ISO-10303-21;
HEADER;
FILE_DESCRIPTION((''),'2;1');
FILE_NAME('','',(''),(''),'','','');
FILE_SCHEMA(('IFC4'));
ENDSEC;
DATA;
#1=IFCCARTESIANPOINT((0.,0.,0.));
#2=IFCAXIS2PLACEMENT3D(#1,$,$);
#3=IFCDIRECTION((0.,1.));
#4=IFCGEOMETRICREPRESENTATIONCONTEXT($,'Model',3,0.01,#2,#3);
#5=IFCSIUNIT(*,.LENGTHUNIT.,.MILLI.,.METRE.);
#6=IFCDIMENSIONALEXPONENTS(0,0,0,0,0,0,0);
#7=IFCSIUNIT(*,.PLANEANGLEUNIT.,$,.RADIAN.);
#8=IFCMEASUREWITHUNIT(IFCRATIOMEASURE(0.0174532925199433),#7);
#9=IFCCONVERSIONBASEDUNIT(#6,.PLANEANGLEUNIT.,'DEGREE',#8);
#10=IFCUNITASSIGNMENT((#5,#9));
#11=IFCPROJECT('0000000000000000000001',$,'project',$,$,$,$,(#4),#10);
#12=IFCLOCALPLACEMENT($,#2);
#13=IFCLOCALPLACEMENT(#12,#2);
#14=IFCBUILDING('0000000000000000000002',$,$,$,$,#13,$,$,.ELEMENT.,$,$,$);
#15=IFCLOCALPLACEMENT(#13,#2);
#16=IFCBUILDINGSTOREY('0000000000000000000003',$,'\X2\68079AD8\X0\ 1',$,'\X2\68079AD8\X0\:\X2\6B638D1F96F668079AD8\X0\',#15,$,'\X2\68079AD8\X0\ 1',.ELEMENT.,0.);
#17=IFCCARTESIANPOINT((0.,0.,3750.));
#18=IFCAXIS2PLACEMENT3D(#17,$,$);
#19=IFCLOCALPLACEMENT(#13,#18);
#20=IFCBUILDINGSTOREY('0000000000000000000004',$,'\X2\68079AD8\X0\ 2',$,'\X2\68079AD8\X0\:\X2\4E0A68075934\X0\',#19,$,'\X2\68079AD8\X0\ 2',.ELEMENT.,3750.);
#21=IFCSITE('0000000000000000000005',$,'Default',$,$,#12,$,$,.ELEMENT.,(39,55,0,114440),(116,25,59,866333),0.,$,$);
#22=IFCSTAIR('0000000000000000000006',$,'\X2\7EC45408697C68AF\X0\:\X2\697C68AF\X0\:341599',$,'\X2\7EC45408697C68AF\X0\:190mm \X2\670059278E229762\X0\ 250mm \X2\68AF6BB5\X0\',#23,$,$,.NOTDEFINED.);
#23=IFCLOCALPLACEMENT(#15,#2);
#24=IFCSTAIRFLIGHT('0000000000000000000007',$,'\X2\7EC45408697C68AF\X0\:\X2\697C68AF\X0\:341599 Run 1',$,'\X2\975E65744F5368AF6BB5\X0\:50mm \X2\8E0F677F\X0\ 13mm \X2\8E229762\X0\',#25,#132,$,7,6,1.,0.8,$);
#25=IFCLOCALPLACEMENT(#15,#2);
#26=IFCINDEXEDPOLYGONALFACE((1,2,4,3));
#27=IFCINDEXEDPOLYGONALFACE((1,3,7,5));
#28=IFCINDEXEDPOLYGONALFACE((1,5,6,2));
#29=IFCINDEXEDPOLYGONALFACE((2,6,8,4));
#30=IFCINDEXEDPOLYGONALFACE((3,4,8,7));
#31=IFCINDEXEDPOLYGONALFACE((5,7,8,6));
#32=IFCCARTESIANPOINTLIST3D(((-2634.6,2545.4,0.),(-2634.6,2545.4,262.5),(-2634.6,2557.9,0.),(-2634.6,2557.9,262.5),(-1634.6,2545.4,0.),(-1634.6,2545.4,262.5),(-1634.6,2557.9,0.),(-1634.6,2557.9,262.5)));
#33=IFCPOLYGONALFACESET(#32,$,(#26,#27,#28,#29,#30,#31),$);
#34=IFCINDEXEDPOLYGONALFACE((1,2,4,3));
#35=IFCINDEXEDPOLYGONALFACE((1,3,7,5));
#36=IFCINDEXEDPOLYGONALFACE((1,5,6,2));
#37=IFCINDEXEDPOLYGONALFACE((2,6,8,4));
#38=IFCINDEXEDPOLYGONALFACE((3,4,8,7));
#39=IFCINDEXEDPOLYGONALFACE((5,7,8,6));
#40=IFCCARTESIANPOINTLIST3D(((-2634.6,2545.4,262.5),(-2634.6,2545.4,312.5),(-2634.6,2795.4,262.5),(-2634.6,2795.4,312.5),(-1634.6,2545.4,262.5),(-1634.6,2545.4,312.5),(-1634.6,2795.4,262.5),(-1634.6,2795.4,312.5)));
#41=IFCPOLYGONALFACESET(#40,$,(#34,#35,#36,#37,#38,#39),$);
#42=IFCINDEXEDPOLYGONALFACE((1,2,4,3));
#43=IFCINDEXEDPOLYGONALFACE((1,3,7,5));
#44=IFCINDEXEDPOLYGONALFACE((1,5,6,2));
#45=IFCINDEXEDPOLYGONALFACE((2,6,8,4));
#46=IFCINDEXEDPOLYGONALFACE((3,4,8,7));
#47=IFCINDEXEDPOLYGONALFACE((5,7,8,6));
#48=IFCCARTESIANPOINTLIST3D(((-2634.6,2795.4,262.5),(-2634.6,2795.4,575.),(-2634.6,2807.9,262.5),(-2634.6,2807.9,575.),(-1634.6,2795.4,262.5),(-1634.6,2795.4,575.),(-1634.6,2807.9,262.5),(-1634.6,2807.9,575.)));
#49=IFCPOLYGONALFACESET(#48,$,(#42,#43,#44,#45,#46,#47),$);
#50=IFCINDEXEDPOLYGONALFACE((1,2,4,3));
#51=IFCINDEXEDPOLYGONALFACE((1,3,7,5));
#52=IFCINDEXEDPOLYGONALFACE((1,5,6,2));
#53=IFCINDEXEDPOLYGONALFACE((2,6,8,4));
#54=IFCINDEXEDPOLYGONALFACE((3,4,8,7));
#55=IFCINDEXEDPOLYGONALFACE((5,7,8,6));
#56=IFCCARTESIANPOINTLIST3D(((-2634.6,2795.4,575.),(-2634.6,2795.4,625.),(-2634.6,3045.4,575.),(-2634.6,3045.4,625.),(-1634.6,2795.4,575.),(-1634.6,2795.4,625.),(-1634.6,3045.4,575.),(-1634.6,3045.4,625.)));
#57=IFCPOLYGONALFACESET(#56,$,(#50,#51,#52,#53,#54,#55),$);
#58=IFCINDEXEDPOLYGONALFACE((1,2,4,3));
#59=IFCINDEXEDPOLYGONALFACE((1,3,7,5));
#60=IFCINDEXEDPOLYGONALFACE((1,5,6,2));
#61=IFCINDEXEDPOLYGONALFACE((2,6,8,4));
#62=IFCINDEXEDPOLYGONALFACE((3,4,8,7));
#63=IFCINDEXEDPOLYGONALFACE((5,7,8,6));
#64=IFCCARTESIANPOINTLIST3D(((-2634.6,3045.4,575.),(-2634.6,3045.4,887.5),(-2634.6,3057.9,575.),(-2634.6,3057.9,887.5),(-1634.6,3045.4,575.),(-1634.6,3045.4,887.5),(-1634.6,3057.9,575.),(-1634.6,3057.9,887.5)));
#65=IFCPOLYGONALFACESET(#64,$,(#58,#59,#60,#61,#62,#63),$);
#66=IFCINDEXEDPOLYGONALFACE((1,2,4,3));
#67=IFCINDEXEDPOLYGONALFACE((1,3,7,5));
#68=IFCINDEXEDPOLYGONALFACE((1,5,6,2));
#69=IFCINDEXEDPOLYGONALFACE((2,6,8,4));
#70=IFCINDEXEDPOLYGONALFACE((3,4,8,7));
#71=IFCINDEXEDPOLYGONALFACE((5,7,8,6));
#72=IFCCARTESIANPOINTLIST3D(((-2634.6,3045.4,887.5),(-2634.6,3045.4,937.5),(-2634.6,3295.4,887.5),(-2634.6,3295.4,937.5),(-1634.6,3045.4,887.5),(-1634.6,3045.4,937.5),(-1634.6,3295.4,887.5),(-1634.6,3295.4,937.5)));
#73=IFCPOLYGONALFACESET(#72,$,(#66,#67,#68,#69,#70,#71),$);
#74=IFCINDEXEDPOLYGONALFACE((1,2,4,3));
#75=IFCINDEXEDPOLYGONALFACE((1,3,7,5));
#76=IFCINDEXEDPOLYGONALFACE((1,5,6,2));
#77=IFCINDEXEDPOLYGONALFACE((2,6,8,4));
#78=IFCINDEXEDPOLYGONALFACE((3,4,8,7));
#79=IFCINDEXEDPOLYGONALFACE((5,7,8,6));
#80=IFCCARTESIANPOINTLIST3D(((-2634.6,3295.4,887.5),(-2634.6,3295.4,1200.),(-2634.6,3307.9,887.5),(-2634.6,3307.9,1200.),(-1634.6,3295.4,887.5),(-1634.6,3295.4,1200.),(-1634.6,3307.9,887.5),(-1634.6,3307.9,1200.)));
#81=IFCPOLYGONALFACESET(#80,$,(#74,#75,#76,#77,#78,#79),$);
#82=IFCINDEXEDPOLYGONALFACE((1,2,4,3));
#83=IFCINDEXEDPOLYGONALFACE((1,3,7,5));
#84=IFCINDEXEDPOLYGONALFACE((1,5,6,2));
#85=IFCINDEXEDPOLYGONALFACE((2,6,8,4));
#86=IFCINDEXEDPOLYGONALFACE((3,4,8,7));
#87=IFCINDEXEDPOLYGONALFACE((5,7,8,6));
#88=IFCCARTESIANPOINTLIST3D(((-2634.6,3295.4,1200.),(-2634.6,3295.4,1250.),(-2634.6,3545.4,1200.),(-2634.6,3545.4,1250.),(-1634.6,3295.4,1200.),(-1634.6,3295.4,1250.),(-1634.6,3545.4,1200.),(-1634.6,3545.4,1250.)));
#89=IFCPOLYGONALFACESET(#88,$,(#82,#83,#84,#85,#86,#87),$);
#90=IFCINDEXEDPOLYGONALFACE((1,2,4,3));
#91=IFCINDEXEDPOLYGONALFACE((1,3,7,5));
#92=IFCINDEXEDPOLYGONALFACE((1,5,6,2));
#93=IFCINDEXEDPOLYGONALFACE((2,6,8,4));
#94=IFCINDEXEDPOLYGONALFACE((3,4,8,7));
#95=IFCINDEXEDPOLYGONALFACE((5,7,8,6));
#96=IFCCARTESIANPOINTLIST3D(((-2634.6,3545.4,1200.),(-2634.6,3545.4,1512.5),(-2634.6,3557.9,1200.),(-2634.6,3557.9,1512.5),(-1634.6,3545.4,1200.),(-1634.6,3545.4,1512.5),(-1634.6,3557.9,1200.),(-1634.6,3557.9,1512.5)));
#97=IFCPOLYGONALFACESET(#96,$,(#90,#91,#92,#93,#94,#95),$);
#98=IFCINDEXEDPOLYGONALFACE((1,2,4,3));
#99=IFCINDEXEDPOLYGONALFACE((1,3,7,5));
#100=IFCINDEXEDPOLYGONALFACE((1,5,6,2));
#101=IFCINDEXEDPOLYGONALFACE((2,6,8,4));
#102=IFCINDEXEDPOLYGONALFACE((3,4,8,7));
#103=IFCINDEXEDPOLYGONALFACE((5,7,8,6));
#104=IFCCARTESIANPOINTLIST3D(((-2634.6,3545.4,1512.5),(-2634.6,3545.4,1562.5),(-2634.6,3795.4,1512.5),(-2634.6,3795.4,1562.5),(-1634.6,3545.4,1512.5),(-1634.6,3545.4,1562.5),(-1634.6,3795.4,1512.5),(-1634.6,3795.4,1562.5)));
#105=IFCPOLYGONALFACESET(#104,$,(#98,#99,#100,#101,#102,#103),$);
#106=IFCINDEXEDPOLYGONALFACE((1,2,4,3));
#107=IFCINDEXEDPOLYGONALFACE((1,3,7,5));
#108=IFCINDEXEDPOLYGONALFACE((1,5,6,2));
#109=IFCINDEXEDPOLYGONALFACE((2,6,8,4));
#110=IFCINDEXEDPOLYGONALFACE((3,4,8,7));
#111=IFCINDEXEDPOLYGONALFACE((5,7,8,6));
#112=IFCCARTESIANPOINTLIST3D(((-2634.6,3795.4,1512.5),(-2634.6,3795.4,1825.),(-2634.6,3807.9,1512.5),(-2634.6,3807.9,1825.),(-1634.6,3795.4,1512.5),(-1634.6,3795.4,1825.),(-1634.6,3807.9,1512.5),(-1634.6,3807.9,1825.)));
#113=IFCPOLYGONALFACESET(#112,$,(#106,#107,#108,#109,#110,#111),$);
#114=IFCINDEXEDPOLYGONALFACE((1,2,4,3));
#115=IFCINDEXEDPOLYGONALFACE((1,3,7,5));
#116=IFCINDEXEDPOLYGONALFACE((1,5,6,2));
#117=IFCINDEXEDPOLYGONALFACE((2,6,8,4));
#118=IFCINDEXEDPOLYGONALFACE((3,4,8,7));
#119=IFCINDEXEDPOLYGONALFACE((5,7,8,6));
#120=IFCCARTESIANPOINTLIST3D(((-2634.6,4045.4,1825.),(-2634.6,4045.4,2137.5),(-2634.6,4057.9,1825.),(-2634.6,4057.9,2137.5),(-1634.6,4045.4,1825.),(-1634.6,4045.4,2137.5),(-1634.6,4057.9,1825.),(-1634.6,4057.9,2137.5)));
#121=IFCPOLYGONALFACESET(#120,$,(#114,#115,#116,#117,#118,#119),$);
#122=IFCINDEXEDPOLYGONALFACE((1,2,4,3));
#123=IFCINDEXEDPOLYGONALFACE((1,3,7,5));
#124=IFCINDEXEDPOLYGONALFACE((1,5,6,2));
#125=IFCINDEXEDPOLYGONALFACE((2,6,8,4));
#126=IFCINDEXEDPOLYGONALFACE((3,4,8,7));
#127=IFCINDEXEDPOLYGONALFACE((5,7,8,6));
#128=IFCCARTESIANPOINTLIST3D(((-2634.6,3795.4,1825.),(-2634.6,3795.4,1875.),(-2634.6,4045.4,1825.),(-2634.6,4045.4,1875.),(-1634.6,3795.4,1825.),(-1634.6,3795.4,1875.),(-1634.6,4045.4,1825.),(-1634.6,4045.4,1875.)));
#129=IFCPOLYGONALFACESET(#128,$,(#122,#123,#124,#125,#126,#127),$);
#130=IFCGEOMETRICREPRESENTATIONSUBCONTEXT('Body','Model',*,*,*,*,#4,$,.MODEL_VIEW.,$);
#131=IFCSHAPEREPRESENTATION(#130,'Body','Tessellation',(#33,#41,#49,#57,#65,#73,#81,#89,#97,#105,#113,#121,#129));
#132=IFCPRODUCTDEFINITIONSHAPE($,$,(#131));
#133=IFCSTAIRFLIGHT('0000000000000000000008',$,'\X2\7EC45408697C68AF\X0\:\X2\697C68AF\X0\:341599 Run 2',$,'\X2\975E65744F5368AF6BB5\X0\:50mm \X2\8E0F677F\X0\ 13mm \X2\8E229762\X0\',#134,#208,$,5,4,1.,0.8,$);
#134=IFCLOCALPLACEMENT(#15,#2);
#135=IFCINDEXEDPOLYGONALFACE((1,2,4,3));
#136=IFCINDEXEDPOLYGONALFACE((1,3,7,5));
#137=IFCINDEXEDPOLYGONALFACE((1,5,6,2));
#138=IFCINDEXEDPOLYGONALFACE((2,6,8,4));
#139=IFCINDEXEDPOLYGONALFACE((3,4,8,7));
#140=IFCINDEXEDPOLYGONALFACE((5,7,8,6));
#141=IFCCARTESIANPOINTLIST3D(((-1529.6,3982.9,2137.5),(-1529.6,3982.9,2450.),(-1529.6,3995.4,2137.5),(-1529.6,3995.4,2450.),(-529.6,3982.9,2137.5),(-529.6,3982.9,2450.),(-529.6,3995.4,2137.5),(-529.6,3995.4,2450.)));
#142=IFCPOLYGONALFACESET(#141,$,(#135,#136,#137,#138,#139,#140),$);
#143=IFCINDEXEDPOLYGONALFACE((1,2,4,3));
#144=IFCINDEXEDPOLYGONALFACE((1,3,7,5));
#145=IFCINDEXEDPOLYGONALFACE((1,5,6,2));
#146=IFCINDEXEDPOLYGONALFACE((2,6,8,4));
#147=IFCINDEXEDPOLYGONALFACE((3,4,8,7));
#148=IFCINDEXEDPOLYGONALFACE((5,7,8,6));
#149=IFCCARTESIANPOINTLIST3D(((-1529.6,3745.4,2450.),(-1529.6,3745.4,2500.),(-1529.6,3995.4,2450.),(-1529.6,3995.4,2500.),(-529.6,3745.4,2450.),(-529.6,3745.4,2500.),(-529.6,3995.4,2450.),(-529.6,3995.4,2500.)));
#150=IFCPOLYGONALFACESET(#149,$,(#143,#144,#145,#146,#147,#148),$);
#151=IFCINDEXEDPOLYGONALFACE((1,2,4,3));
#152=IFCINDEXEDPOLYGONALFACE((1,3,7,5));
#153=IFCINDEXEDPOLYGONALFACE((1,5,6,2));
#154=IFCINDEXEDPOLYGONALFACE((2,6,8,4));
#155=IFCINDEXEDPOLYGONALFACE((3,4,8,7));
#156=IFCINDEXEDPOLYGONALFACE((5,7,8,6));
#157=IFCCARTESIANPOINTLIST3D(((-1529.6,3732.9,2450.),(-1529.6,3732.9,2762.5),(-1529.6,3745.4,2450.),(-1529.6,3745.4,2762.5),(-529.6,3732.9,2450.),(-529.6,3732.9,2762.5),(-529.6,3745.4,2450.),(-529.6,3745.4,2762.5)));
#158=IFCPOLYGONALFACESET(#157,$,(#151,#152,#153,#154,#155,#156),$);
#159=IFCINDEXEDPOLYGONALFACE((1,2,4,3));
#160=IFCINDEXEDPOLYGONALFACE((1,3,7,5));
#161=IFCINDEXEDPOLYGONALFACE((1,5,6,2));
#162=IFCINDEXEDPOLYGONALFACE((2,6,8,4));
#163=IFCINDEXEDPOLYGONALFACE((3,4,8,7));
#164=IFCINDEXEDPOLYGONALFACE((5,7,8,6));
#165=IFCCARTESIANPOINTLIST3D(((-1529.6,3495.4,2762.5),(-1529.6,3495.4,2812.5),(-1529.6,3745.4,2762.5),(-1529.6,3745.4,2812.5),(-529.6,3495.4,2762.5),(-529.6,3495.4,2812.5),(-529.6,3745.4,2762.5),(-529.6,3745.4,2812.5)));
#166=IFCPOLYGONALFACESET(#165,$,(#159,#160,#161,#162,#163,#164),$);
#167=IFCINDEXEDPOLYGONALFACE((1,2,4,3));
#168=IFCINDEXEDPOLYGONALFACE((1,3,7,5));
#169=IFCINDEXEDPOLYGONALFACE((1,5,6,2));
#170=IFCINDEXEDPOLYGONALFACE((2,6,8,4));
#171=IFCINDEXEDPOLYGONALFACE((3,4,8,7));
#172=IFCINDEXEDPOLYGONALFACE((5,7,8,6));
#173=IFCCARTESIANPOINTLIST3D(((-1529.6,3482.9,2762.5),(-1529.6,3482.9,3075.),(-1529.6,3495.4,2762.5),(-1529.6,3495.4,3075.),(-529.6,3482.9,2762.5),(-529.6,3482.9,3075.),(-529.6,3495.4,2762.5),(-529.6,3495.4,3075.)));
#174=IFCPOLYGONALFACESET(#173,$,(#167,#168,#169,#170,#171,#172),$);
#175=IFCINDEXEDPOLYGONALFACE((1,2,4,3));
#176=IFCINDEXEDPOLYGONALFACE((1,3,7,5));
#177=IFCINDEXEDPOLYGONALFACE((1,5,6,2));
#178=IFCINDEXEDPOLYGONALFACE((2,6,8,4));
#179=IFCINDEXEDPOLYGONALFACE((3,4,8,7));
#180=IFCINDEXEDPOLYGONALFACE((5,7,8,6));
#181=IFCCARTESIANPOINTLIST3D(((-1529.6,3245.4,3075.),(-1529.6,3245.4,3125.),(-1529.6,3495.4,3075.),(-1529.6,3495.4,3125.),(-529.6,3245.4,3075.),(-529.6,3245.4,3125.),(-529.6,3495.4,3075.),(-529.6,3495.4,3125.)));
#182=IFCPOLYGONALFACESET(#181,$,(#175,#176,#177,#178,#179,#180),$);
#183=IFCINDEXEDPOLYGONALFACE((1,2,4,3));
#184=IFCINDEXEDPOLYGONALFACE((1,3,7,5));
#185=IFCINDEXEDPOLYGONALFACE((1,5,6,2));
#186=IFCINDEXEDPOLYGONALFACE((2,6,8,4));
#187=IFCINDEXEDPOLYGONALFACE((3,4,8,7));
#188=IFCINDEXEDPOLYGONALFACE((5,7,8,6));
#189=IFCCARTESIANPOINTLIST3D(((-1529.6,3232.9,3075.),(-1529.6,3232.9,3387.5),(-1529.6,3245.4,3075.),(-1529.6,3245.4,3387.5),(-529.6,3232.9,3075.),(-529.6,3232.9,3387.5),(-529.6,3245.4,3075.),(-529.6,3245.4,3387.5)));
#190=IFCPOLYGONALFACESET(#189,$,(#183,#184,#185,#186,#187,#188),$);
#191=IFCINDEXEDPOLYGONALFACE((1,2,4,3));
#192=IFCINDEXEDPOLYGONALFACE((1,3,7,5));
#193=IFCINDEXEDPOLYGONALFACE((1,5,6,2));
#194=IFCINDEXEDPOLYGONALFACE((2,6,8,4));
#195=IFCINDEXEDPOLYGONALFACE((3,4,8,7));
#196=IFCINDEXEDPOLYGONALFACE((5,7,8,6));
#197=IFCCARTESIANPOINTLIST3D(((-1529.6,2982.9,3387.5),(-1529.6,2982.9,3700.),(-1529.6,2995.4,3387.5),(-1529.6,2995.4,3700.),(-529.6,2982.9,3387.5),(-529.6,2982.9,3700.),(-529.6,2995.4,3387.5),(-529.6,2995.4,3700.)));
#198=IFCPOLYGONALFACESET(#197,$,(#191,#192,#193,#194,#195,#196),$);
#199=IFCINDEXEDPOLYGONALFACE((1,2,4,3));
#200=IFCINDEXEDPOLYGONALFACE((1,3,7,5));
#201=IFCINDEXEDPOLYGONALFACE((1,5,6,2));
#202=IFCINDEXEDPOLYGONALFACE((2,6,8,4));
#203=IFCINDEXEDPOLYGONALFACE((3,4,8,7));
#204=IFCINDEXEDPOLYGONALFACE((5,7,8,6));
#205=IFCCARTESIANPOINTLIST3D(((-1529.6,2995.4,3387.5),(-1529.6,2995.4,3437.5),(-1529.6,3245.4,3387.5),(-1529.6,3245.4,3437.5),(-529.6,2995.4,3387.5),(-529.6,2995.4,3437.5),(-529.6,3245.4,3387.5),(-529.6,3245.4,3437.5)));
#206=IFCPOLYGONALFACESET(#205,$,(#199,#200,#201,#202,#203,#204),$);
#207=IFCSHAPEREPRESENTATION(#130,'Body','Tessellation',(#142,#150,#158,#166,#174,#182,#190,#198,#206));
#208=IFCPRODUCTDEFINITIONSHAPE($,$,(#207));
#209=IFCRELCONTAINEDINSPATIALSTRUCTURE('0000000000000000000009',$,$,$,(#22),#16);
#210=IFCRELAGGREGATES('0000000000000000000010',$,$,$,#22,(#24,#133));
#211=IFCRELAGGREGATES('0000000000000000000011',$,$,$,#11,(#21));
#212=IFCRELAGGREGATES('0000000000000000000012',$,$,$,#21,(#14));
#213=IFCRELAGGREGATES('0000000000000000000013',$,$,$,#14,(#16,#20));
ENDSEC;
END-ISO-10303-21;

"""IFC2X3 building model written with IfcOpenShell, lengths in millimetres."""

from ifc_helpers import new_model, entity, si_unit, converted_unit, direction, frame, frame_2d, origin, origin_2d_with_axis, place, context, subcontext, project, spatial, rectangle, extrude, element, aggregate, save


model = new_model("IFC2X3")

# Units and contexts
model_context = context("Model", 3, precision=0.01, world=origin(), true_north=direction((0.0, 1.0)))
body_context = subcontext(model_context, "Body", "Model", "MODEL_VIEW")
ifc_project = project(units=[si_unit("LENGTHUNIT", "METRE", prefix="MILLI"), converted_unit("PLANEANGLEUNIT", "DEGREE", entity("IfcRatioMeasure", 0.0174532925199433), si_unit("PLANEANGLEUNIT", "RADIAN"), dimensions=[0, 0, 0, 0, 0, 0, 0])], contexts=[model_context])

# Site, building, storey
site_placement = place(None, origin())
site = spatial("IfcSite", under=ifc_project, at=site_placement, Name="Default", CompositionType="ELEMENT", RefLatitude=(39, 55, 0, 114440), RefLongitude=(116, 25, 59, 866333), RefElevation=0.0)
building_placement = place(site_placement, origin())
building = spatial("IfcBuilding", under=site, at=building_placement, CompositionType="ELEMENT")
storey_1_placement = place(building_placement, origin())
storey_1 = spatial("IfcBuildingStorey", under=building, at=storey_1_placement, Name="标高 1", ObjectType="标高:正负零标高", LongName="标高 1", CompositionType="ELEMENT", Elevation=0.0)

# Stair
stair_placement = place(storey_1_placement, origin())
stair = element("IfcStair", 1, at=stair_placement, inside=storey_1, Name="组合楼梯:楼梯:341599", ObjectType="组合楼梯:190mm 最大踢面 250mm 梯段", ShapeType="NOTDEFINED")

# Shared definitions
storey_2_placement = place(building_placement, frame((0.0, 0.0, 3750.0)))
storey_2 = spatial("IfcBuildingStorey", under=building, at=storey_2_placement, Name="标高 2", ObjectType="标高:上标头", LongName="标高 2", CompositionType="ELEMENT", Elevation=3750.0)

# Stair flights
stair_flight_1_placement = place(stair_placement, origin())
stair_flight_1 = element("IfcStairFlight", 2, at=stair_flight_1_placement, Name="组合楼梯:楼梯:341599 Run 1", ObjectType="非整体梯段:50mm 踏板 13mm 踢面", NumberOfRiser=7, NumberOfTreads=6, RiserHeight=1.0, TreadLength=0.8, context=body_context, shape_type="SweptSolid", body=[
    extrude(rectangle(XDim=1000.0, YDim=12.5, at=frame_2d((0.0, 0.0), x_axis=(1.0, 0.0))), frame((-2134.6, 2551.6, 0.0), z_axis=(0.0, 0.0, 1.0), x_axis=(-1.0, 0.0, 0.0)), (0.0, 0.0, 1.0), 262.5),
    extrude(rectangle(XDim=250.0, YDim=1000.0, at=frame_2d((0.0, 0.0), x_axis=(1.0, 0.0))), frame((-2134.6, 2670.4, 262.5), z_axis=(0.0, 0.0, 1.0), x_axis=(0.0, -1.0, 0.0)), (0.0, 0.0, 1.0), 50.0),
    extrude(rectangle(XDim=1000.0, YDim=12.5, at=frame_2d((0.0, 0.0), x_axis=(1.0, 0.0))), frame((-2134.6, 2801.6, 262.5), z_axis=(0.0, 0.0, 1.0), x_axis=(-1.0, 0.0, 0.0)), (0.0, 0.0, 1.0), 312.5),
    extrude(rectangle(XDim=250.0, YDim=1000.0, at=origin_2d_with_axis()), frame((-2134.6, 2920.4, 575.0), z_axis=(0.0, 0.0, 1.0), x_axis=(0.0, -1.0, 0.0)), (0.0, 0.0, 1.0), 50.0),
    extrude(rectangle(XDim=1000.0, YDim=12.5, at=frame_2d((0.0, 0.0), x_axis=(1.0, 0.0))), frame((-2134.6, 3051.6, 575.0), z_axis=(0.0, 0.0, 1.0), x_axis=(-1.0, 0.0, 0.0)), (0.0, 0.0, 1.0), 312.5),
    extrude(rectangle(XDim=250.0, YDim=1000.0, at=frame_2d((0.0, 0.0), x_axis=(1.0, 0.0))), frame((-2134.6, 3170.4, 887.5), z_axis=(0.0, 0.0, 1.0), x_axis=(0.0, -1.0, 0.0)), (0.0, 0.0, 1.0), 50.0),
    extrude(rectangle(XDim=1000.0, YDim=12.5, at=frame_2d((0.0, 0.0), x_axis=(1.0, 0.0))), frame((-2134.6, 3301.6, 887.5), z_axis=(0.0, 0.0, 1.0), x_axis=(-1.0, 0.0, 0.0)), (0.0, 0.0, 1.0), 312.5),
    extrude(rectangle(XDim=250.0, YDim=1000.0, at=frame_2d((0.0, 0.0), x_axis=(1.0, 0.0))), frame((-2134.6, 3420.4, 1200.0), z_axis=(0.0, 0.0, 1.0), x_axis=(0.0, -1.0, 0.0)), (0.0, 0.0, 1.0), 50.0),
    extrude(rectangle(XDim=1000.0, YDim=12.5, at=frame_2d((0.0, 0.0), x_axis=(1.0, 0.0))), frame((-2134.6, 3551.6, 1200.0), z_axis=(0.0, 0.0, 1.0), x_axis=(-1.0, 0.0, 0.0)), (0.0, 0.0, 1.0), 312.5),
    extrude(rectangle(XDim=250.0, YDim=1000.0, at=frame_2d((0.0, 0.0), x_axis=(1.0, 0.0))), frame((-2134.6, 3670.4, 1512.5), z_axis=(0.0, 0.0, 1.0), x_axis=(0.0, -1.0, 0.0)), (0.0, 0.0, 1.0), 50.0),
    extrude(rectangle(XDim=1000.0, YDim=12.5, at=frame_2d((0.0, 0.0), x_axis=(1.0, 0.0))), frame((-2134.6, 3801.6, 1512.5), z_axis=(0.0, 0.0, 1.0), x_axis=(-1.0, 0.0, 0.0)), (0.0, 0.0, 1.0), 312.5),
    extrude(rectangle(XDim=1000.0, YDim=12.5, at=frame_2d((0.0, 0.0), x_axis=(1.0, 0.0))), frame((-2134.6, 4051.6, 1825.0), z_axis=(0.0, 0.0, 1.0), x_axis=(-1.0, 0.0, 0.0)), (0.0, 0.0, 1.0), 312.5),
    extrude(rectangle(XDim=250.0, YDim=1000.0, at=frame_2d((0.0, 0.0), x_axis=(1.0, 0.0))), frame((-2134.6, 3920.4, 1825.0), z_axis=(0.0, 0.0, 1.0), x_axis=(0.0, -1.0, 0.0)), (0.0, 0.0, 1.0), 50.0),
])
stair_flight_2_placement = place(stair_placement, origin())
stair_flight_2 = element("IfcStairFlight", 3, at=stair_flight_2_placement, Name="组合楼梯:楼梯:341599 Run 2", ObjectType="非整体梯段:50mm 踏板 13mm 踢面", NumberOfRiser=5, NumberOfTreads=4, RiserHeight=1.0, TreadLength=0.8, context=body_context, shape_type="SweptSolid", body=[
    extrude(rectangle(XDim=1000.0, YDim=12.5, at=origin_2d_with_axis()), frame((-1029.6, 3989.1, 2137.5)), (0.0, 0.0, 1.0), 312.5),
    extrude(rectangle(XDim=250.0, YDim=1000.0, at=frame_2d((0.0, 0.0), x_axis=(1.0, 0.0))), frame((-1029.6, 3870.4, 2450.0), z_axis=(0.0, 0.0, 1.0), x_axis=(0.0, 1.0, 0.0)), (0.0, 0.0, 1.0), 50.0),
    extrude(rectangle(XDim=1000.0, YDim=12.5, at=frame_2d((0.0, 0.0), x_axis=(1.0, 0.0))), frame((-1029.6, 3739.1, 2450.0)), (0.0, 0.0, 1.0), 312.5),
    extrude(rectangle(XDim=250.0, YDim=1000.0, at=frame_2d((0.0, 0.0), x_axis=(1.0, 0.0))), frame((-1029.6, 3620.4, 2762.5), z_axis=(0.0, 0.0, 1.0), x_axis=(0.0, 1.0, 0.0)), (0.0, 0.0, 1.0), 50.0),
    extrude(rectangle(XDim=1000.0, YDim=12.5, at=origin_2d_with_axis()), frame((-1029.6, 3489.1, 2762.5)), (0.0, 0.0, 1.0), 312.5),
    extrude(rectangle(XDim=250.0, YDim=1000.0, at=frame_2d((0.0, 0.0), x_axis=(1.0, 0.0))), frame((-1029.6, 3370.4, 3075.0), z_axis=(0.0, 0.0, 1.0), x_axis=(0.0, 1.0, 0.0)), (0.0, 0.0, 1.0), 50.0),
    extrude(rectangle(XDim=1000.0, YDim=12.5, at=origin_2d_with_axis()), frame((-1029.6, 3239.1, 3075.0)), (0.0, 0.0, 1.0), 312.5),
    extrude(rectangle(XDim=1000.0, YDim=12.5, at=frame_2d((0.0, 0.0), x_axis=(1.0, 0.0))), frame((-1029.6, 2989.1, 3387.5)), (0.0, 0.0, 1.0), 312.5),
    extrude(rectangle(XDim=250.0, YDim=1000.0, at=frame_2d((0.0, 0.0), x_axis=(1.0, 0.0))), frame((-1029.6, 3120.4, 3387.5), z_axis=(0.0, 0.0, 1.0), x_axis=(0.0, 1.0, 0.0)), (0.0, 0.0, 1.0), 50.0),
])
aggregate(stair, [stair_flight_1, stair_flight_2])

save(model, "model.ifc")
